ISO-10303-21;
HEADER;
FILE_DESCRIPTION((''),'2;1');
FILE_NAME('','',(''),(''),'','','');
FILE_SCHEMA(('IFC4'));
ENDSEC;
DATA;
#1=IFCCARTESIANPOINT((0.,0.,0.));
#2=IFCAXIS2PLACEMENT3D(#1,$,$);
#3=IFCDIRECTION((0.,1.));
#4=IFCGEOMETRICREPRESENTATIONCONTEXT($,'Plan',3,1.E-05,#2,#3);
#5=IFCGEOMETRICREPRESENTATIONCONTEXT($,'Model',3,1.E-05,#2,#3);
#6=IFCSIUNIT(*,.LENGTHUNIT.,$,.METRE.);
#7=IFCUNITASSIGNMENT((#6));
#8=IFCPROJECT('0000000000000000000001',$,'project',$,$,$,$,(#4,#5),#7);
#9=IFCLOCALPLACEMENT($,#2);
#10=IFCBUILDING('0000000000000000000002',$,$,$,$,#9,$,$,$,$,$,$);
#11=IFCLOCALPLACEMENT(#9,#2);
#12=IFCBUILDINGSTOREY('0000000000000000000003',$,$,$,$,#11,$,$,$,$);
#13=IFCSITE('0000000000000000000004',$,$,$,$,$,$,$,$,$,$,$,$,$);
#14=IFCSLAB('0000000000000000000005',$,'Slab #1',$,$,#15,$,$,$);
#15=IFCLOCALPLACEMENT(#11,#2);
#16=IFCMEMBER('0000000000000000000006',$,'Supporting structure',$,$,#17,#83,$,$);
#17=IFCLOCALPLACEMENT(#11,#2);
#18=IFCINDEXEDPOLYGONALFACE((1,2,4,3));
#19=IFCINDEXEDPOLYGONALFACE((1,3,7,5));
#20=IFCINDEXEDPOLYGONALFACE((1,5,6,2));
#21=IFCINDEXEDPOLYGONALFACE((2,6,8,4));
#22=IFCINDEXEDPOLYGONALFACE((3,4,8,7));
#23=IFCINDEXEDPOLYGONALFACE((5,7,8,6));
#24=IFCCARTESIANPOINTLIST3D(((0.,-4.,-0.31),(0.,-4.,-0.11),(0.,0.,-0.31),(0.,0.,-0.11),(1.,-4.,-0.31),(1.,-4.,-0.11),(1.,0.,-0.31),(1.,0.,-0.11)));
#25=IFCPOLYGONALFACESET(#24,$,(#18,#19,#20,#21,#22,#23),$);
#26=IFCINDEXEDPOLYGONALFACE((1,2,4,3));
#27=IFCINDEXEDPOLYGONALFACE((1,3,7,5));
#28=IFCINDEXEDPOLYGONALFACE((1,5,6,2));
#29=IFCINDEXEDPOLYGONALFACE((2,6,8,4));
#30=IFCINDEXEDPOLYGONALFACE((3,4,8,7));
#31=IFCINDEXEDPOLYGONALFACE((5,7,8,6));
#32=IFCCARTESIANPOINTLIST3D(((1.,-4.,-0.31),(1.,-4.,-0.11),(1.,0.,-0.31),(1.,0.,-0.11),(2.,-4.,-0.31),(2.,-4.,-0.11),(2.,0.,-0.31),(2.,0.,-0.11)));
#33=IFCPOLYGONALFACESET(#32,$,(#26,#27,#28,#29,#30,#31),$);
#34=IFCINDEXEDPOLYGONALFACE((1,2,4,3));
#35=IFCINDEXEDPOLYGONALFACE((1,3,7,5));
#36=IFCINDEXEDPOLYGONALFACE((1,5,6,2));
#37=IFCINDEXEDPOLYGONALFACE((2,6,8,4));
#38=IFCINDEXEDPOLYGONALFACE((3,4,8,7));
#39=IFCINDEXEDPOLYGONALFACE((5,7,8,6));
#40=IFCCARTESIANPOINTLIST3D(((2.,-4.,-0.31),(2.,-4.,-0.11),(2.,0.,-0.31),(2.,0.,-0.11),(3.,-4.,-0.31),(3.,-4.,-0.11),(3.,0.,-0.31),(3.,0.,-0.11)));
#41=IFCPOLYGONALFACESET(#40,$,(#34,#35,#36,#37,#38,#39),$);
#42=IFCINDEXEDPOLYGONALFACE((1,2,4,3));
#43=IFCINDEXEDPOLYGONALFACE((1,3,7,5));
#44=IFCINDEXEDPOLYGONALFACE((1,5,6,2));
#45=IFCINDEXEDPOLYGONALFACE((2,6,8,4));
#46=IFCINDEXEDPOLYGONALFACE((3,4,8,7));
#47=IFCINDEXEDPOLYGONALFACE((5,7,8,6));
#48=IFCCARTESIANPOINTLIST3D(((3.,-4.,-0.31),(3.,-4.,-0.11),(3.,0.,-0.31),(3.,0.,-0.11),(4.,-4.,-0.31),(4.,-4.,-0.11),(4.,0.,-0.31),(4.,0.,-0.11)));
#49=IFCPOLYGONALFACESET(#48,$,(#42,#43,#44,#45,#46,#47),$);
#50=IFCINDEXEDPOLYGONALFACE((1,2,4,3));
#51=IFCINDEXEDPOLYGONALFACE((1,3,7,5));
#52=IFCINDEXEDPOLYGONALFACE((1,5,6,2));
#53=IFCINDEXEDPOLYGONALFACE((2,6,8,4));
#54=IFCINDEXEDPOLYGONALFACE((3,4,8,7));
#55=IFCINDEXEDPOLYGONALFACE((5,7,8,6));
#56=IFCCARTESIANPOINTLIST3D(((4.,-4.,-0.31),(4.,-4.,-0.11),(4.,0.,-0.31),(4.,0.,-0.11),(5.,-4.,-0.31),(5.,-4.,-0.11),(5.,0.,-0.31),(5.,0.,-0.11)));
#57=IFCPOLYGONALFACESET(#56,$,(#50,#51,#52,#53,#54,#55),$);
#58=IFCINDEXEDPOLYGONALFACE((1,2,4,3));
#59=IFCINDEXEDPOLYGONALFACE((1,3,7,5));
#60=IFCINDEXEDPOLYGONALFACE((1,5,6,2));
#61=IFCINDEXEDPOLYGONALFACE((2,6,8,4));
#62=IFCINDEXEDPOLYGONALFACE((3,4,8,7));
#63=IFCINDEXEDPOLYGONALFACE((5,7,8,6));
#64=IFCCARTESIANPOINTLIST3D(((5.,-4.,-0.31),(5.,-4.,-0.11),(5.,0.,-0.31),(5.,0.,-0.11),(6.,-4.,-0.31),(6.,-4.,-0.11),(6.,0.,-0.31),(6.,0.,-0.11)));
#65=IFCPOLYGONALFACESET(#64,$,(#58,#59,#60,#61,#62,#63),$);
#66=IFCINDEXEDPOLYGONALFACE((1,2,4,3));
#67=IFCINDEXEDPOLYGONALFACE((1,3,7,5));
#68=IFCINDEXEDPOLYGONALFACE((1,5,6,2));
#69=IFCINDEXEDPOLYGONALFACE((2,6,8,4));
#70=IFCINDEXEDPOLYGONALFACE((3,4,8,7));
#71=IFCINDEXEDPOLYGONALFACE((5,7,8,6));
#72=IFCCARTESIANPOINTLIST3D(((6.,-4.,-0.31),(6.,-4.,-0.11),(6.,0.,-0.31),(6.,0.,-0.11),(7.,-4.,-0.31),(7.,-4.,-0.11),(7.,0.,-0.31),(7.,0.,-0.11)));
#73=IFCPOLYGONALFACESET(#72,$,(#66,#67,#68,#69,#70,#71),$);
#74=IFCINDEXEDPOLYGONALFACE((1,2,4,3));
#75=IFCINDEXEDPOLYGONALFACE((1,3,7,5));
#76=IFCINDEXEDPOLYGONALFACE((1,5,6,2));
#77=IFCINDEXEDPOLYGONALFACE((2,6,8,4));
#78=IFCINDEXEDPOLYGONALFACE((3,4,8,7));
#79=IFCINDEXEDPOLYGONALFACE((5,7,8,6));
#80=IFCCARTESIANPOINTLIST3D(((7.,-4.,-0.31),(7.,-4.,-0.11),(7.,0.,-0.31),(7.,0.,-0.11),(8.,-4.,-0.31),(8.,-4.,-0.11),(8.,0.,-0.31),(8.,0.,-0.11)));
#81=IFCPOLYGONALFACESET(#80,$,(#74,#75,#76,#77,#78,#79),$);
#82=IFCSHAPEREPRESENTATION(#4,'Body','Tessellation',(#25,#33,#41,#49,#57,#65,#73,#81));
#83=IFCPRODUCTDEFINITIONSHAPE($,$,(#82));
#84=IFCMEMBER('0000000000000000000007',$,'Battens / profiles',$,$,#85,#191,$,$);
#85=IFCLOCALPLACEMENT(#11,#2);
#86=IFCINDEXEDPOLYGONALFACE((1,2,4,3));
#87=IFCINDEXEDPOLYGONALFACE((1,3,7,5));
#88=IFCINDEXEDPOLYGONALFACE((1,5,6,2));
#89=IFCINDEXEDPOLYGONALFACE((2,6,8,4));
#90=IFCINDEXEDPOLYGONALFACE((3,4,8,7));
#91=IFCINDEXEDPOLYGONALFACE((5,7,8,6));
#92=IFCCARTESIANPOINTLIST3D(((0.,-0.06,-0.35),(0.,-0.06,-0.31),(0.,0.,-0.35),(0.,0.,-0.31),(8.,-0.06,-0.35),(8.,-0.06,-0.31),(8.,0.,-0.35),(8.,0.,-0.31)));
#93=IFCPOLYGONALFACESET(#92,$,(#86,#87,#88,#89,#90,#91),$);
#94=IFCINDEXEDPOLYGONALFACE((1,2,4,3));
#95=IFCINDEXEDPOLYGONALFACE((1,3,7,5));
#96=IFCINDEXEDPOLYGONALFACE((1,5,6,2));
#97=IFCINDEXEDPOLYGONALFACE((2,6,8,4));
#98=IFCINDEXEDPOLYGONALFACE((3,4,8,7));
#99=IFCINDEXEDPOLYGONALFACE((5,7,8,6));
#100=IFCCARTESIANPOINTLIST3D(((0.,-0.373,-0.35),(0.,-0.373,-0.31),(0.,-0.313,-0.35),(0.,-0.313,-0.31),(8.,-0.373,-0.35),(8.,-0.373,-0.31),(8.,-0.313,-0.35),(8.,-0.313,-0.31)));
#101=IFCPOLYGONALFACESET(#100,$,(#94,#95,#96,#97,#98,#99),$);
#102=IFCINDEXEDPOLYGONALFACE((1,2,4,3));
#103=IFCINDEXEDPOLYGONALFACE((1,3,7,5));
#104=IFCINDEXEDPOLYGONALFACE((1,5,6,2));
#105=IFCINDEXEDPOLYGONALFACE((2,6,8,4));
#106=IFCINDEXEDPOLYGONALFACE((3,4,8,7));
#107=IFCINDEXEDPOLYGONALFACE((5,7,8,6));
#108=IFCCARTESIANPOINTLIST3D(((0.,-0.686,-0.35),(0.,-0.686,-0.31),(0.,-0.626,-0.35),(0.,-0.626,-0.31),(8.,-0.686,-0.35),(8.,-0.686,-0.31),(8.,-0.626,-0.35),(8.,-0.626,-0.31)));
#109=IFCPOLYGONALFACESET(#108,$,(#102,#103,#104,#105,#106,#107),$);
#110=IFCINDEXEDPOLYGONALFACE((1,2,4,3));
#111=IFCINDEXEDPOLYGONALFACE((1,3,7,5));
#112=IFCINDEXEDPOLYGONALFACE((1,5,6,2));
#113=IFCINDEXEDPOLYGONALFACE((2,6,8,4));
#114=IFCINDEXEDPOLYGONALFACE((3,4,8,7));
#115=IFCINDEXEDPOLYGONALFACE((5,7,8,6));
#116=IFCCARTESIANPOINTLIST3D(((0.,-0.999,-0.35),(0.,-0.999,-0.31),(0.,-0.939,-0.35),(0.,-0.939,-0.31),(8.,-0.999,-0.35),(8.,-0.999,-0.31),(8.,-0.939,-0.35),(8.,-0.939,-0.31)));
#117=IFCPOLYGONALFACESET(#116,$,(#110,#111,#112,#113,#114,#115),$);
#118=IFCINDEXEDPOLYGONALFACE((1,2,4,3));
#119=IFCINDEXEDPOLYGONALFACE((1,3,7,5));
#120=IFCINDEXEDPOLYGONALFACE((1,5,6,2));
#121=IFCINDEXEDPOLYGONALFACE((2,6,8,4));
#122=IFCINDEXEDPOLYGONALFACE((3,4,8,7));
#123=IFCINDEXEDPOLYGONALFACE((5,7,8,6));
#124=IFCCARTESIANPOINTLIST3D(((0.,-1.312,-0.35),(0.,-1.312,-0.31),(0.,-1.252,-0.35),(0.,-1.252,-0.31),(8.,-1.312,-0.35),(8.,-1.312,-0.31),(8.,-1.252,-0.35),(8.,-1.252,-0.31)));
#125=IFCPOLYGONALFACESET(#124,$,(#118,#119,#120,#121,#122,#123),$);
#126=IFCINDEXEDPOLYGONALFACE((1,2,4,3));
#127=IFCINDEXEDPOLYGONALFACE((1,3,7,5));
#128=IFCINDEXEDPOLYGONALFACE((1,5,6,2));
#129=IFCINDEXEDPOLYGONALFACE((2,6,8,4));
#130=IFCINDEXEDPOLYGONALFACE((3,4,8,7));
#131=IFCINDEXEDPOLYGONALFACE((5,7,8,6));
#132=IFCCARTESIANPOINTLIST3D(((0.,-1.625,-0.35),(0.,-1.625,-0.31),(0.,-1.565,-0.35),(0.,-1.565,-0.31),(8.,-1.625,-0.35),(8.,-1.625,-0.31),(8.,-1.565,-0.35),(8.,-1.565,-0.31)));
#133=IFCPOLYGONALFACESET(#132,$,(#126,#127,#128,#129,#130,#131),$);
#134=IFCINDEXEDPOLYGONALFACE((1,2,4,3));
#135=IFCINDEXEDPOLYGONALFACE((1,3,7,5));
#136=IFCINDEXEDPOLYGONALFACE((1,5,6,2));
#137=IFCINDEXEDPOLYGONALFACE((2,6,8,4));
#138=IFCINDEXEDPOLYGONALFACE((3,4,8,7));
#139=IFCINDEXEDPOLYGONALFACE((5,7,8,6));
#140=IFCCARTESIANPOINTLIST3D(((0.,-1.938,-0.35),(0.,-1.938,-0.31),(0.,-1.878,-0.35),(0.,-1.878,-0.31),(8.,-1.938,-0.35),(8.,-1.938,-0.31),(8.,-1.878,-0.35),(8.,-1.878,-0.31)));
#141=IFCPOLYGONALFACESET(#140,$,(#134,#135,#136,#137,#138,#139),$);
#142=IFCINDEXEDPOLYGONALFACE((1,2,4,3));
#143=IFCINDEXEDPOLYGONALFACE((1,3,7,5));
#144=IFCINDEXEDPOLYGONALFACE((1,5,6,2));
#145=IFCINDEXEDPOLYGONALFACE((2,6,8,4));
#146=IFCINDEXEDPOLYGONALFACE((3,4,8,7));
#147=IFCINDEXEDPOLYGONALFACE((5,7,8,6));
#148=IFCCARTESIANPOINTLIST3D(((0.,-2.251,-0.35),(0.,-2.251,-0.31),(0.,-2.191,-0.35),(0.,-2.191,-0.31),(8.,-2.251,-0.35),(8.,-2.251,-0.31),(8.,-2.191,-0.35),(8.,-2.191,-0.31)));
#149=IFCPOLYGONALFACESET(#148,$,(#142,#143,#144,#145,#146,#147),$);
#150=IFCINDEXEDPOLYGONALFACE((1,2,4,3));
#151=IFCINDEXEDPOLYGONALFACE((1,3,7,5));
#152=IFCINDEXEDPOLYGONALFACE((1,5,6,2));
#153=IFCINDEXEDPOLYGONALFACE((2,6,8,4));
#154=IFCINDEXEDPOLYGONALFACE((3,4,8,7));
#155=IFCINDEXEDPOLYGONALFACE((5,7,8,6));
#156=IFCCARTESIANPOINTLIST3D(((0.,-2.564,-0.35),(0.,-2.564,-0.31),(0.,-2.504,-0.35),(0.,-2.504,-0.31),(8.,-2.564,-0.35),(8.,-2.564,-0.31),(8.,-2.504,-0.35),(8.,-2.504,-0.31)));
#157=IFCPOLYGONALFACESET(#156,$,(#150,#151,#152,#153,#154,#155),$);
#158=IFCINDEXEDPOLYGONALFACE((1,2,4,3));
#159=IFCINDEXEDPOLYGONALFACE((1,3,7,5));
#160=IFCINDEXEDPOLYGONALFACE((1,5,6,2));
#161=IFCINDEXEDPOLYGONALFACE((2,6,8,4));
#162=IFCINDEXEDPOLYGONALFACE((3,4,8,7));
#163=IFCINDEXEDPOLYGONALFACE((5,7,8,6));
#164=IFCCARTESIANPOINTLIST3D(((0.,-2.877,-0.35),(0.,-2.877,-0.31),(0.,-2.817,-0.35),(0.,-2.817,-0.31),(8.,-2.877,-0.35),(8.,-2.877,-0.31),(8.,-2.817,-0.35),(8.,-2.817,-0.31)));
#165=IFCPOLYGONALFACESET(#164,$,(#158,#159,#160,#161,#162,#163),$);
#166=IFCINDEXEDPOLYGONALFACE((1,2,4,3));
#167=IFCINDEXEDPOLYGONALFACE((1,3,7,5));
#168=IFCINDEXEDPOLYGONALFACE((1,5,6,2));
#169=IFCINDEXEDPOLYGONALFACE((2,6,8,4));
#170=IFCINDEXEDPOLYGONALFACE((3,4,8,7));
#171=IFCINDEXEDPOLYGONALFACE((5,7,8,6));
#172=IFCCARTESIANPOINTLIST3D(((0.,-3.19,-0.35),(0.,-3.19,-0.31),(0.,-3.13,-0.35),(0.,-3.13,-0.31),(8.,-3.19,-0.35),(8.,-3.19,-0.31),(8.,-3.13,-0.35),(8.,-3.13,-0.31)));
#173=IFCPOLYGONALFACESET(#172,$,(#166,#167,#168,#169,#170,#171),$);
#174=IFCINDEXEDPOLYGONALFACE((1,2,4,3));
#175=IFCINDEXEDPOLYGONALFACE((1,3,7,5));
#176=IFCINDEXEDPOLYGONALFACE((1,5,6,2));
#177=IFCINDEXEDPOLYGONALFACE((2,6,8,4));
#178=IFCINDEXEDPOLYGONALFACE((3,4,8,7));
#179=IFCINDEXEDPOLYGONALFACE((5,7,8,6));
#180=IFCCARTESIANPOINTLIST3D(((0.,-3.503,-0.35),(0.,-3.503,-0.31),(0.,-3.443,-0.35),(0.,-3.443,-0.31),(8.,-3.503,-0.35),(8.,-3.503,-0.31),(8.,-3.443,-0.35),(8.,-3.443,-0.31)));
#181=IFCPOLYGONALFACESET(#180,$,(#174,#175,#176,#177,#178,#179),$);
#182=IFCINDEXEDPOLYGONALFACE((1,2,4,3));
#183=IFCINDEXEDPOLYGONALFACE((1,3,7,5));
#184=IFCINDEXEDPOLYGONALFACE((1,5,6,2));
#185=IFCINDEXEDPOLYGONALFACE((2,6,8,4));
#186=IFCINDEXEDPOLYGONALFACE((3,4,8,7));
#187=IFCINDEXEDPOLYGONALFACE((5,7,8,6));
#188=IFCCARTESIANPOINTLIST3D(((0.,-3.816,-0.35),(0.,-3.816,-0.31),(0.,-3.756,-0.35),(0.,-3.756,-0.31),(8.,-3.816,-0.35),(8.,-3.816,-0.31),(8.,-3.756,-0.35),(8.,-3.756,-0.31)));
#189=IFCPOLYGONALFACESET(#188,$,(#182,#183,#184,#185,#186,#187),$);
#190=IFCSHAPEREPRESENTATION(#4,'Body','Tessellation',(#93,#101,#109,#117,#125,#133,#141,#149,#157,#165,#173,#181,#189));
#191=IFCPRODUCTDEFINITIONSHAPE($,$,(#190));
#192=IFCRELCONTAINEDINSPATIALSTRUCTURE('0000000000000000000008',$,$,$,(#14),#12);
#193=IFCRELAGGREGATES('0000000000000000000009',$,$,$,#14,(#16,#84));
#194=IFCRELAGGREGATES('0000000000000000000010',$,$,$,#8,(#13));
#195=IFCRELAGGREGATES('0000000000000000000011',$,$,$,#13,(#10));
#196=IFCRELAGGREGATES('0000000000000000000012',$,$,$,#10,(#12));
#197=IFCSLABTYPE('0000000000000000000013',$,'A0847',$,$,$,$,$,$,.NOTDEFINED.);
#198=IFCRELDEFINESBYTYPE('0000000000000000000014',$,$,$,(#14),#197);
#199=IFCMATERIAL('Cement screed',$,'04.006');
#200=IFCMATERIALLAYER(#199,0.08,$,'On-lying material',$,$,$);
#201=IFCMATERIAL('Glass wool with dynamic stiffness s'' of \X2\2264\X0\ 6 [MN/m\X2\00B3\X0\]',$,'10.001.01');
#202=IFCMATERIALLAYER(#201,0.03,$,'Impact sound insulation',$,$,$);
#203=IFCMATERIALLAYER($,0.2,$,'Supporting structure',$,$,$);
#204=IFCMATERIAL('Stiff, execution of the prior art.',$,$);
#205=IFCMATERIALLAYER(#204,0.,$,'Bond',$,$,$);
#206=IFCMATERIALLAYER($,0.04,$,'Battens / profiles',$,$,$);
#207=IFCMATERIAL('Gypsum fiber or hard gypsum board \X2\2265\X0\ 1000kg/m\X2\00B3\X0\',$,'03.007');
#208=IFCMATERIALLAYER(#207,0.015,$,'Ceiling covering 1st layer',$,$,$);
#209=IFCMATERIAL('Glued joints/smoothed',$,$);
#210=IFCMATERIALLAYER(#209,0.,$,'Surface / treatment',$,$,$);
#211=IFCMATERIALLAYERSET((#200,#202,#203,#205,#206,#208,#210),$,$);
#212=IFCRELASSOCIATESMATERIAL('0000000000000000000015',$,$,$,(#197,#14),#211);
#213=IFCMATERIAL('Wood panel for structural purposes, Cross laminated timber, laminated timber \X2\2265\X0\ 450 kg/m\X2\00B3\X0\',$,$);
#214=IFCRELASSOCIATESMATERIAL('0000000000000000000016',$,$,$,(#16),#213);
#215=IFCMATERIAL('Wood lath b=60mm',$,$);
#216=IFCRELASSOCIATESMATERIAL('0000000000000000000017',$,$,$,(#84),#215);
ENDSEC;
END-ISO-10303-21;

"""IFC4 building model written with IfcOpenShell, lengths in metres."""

from ifc_helpers import new_model, si_unit, direction, frame, frame_2d, origin, place, context, project, spatial, rectangle, extrude, material, layer, layer_set, type_object, element, aggregate, save


model = new_model("IFC4")

# Units and contexts
plan_context = context("Plan", 3, precision=1e-05, world=origin(), true_north=direction((0.0, 1.0)))
model_context = context("Model", 3, precision=1e-05, world=origin(), true_north=direction((0.0, 1.0)))
ifc_project = project(units=[si_unit("LENGTHUNIT", "METRE")], contexts=[plan_context, model_context])

# Site, building, storey
site = spatial("IfcSite", under=ifc_project)
building_placement = place(None, origin())
building = spatial("IfcBuilding", under=site, at=building_placement)
storey_placement = place(building_placement, origin())
storey = spatial("IfcBuildingStorey", under=building, at=storey_placement)

# Slab, members
ifc_material_1 = material(Name="Cement screed", Category="04.006")
ifc_layer_1 = layer(ifc_material_1, 0.08, Name="On-lying material")
ifc_material_2 = material(Name="Glass wool with dynamic stiffness s' of ≤ 6 [MN/m³]", Category="10.001.01")
ifc_layer_2 = layer(ifc_material_2, 0.03, Name="Impact sound insulation")
ifc_layer_3 = layer(None, 0.2, Name="Supporting structure")
ifc_material_3 = material(Name="Stiff, execution of the prior art.")
ifc_layer_4 = layer(ifc_material_3, 0.0, Name="Bond")
ifc_layer_5 = layer(None, 0.04, Name="Battens / profiles")
ifc_material_4 = material(Name="Gypsum fiber or hard gypsum board ≥ 1000kg/m³", Category="03.007")
ifc_layer_6 = layer(ifc_material_4, 0.015, Name="Ceiling covering 1st layer")
ifc_material_5 = material(Name="Glued joints/smoothed")
ifc_layer_7 = layer(ifc_material_5, 0.0, Name="Surface / treatment")
ifc_layer_set = layer_set([ifc_layer_1, ifc_layer_2, ifc_layer_3, ifc_layer_4, ifc_layer_5, ifc_layer_6, ifc_layer_7])
slab_type = type_object("IfcSlabType", Name="A0847", PredefinedType="NOTDEFINED", material=ifc_layer_set)
slab_placement = place(None, frame((0.0, 0.0, 0.0), z_axis=(0.0, 0.0, -1.0), x_axis=(1.0, 0.0, 0.0)))
slab = element("IfcSlab", 1, at=slab_placement, inside=storey, type_object=slab_type, material=ifc_layer_set, Name="Slab #1")
ifc_material_6 = material(Name="Wood panel for structural purposes, Cross laminated timber, laminated timber ≥ 450 kg/m³")
member_1_placement = place(slab_placement, origin())
member_1 = element("IfcMember", 2, at=member_1_placement, material=ifc_material_6, Name="Supporting structure", context=plan_context, shape_type="SweptSolid", body=[
    extrude(rectangle(XDim=1.0, YDim=0.2, at=frame_2d((0.5, 0.1), x_axis=(1.0, 0.0))), frame((0.0, 4.0, 0.11), z_axis=(0.0, -1.0, 0.0), x_axis=(1.0, 0.0, 0.0)), (0.0, 0.0, 1.0), 4.0),
    extrude(rectangle(XDim=1.0, YDim=0.2, at=frame_2d((0.5, 0.1), x_axis=(1.0, 0.0))), frame((1.0, 4.0, 0.11), z_axis=(0.0, -1.0, 0.0), x_axis=(1.0, 0.0, 0.0)), (0.0, 0.0, 1.0), 4.0),
    extrude(rectangle(XDim=1.0, YDim=0.2, at=frame_2d((0.5, 0.1), x_axis=(1.0, 0.0))), frame((2.0, 4.0, 0.11), z_axis=(0.0, -1.0, 0.0), x_axis=(1.0, 0.0, 0.0)), (0.0, 0.0, 1.0), 4.0),
    extrude(rectangle(XDim=1.0, YDim=0.2, at=frame_2d((0.5, 0.1), x_axis=(1.0, 0.0))), frame((3.0, 4.0, 0.11), z_axis=(0.0, -1.0, 0.0), x_axis=(1.0, 0.0, 0.0)), (0.0, 0.0, 1.0), 4.0),
    extrude(rectangle(XDim=1.0, YDim=0.2, at=frame_2d((0.5, 0.1), x_axis=(1.0, 0.0))), frame((4.0, 4.0, 0.11), z_axis=(0.0, -1.0, 0.0), x_axis=(1.0, 0.0, 0.0)), (0.0, 0.0, 1.0), 4.0),
    extrude(rectangle(XDim=1.0, YDim=0.2, at=frame_2d((0.5, 0.1), x_axis=(1.0, 0.0))), frame((5.0, 4.0, 0.11), z_axis=(0.0, -1.0, 0.0), x_axis=(1.0, 0.0, 0.0)), (0.0, 0.0, 1.0), 4.0),
    extrude(rectangle(XDim=1.0, YDim=0.2, at=frame_2d((0.5, 0.1), x_axis=(1.0, 0.0))), frame((6.0, 4.0, 0.11), z_axis=(0.0, -1.0, 0.0), x_axis=(1.0, 0.0, 0.0)), (0.0, 0.0, 1.0), 4.0),
    extrude(rectangle(XDim=1.0, YDim=0.2, at=frame_2d((0.5, 0.1), x_axis=(1.0, 0.0))), frame((7.0, 4.0, 0.11), z_axis=(0.0, -1.0, 0.0), x_axis=(1.0, 0.0, 0.0)), (0.0, 0.0, 1.0), 4.0),
])
ifc_material_7 = material(Name="Wood lath b=60mm")
member_2_placement = place(slab_placement, origin())
member_2 = element("IfcMember", 3, at=member_2_placement, material=ifc_material_7, Name="Battens / profiles", context=plan_context, shape_type="SweptSolid", body=[
    extrude(rectangle(XDim=0.06, YDim=0.04, at=frame_2d((0.03, 0.02), x_axis=(1.0, 0.0))), frame((0.0, 0.0, 0.31), z_axis=(1.0, 0.0, 0.0), x_axis=(0.0, 1.0, 0.0)), (0.0, 0.0, 1.0), 8.0),
    extrude(rectangle(XDim=0.06, YDim=0.04, at=frame_2d((0.03, 0.02), x_axis=(1.0, 0.0))), frame((0.0, 0.313, 0.31), z_axis=(1.0, 0.0, 0.0), x_axis=(0.0, 1.0, 0.0)), (0.0, 0.0, 1.0), 8.0),
    extrude(rectangle(XDim=0.06, YDim=0.04, at=frame_2d((0.03, 0.02), x_axis=(1.0, 0.0))), frame((0.0, 0.626, 0.31), z_axis=(1.0, 0.0, 0.0), x_axis=(0.0, 1.0, 0.0)), (0.0, 0.0, 1.0), 8.0),
    extrude(rectangle(XDim=0.06, YDim=0.04, at=frame_2d((0.03, 0.02), x_axis=(1.0, 0.0))), frame((0.0, 0.939, 0.31), z_axis=(1.0, 0.0, 0.0), x_axis=(0.0, 1.0, 0.0)), (0.0, 0.0, 1.0), 8.0),
    extrude(rectangle(XDim=0.06, YDim=0.04, at=frame_2d((0.03, 0.02), x_axis=(1.0, 0.0))), frame((0.0, 1.252, 0.31), z_axis=(1.0, 0.0, 0.0), x_axis=(0.0, 1.0, 0.0)), (0.0, 0.0, 1.0), 8.0),
    extrude(rectangle(XDim=0.06, YDim=0.04, at=frame_2d((0.03, 0.02), x_axis=(1.0, 0.0))), frame((0.0, 1.565, 0.31), z_axis=(1.0, 0.0, 0.0), x_axis=(0.0, 1.0, 0.0)), (0.0, 0.0, 1.0), 8.0),
    extrude(rectangle(XDim=0.06, YDim=0.04, at=frame_2d((0.03, 0.02), x_axis=(1.0, 0.0))), frame((0.0, 1.878, 0.31), z_axis=(1.0, 0.0, 0.0), x_axis=(0.0, 1.0, 0.0)), (0.0, 0.0, 1.0), 8.0),
    extrude(rectangle(XDim=0.06, YDim=0.04, at=frame_2d((0.03, 0.02), x_axis=(1.0, 0.0))), frame((0.0, 2.191, 0.31), z_axis=(1.0, 0.0, 0.0), x_axis=(0.0, 1.0, 0.0)), (0.0, 0.0, 1.0), 8.0),
    extrude(rectangle(XDim=0.06, YDim=0.04, at=frame_2d((0.03, 0.02), x_axis=(1.0, 0.0))), frame((0.0, 2.504, 0.31), z_axis=(1.0, 0.0, 0.0), x_axis=(0.0, 1.0, 0.0)), (0.0, 0.0, 1.0), 8.0),
    extrude(rectangle(XDim=0.06, YDim=0.04, at=frame_2d((0.03, 0.02), x_axis=(1.0, 0.0))), frame((0.0, 2.817, 0.31), z_axis=(1.0, 0.0, 0.0), x_axis=(0.0, 1.0, 0.0)), (0.0, 0.0, 1.0), 8.0),
    extrude(rectangle(XDim=0.06, YDim=0.04, at=frame_2d((0.03, 0.02), x_axis=(1.0, 0.0))), frame((0.0, 3.13, 0.31), z_axis=(1.0, 0.0, 0.0), x_axis=(0.0, 1.0, 0.0)), (0.0, 0.0, 1.0), 8.0),
    extrude(rectangle(XDim=0.06, YDim=0.04, at=frame_2d((0.03, 0.02), x_axis=(1.0, 0.0))), frame((0.0, 3.443, 0.31), z_axis=(1.0, 0.0, 0.0), x_axis=(0.0, 1.0, 0.0)), (0.0, 0.0, 1.0), 8.0),
    extrude(rectangle(XDim=0.06, YDim=0.04, at=frame_2d((0.03, 0.02), x_axis=(1.0, 0.0))), frame((0.0, 3.756, 0.31), z_axis=(1.0, 0.0, 0.0), x_axis=(0.0, 1.0, 0.0)), (0.0, 0.0, 1.0), 8.0),
])
aggregate(slab, [member_1, member_2])

save(model, "model.ifc")
